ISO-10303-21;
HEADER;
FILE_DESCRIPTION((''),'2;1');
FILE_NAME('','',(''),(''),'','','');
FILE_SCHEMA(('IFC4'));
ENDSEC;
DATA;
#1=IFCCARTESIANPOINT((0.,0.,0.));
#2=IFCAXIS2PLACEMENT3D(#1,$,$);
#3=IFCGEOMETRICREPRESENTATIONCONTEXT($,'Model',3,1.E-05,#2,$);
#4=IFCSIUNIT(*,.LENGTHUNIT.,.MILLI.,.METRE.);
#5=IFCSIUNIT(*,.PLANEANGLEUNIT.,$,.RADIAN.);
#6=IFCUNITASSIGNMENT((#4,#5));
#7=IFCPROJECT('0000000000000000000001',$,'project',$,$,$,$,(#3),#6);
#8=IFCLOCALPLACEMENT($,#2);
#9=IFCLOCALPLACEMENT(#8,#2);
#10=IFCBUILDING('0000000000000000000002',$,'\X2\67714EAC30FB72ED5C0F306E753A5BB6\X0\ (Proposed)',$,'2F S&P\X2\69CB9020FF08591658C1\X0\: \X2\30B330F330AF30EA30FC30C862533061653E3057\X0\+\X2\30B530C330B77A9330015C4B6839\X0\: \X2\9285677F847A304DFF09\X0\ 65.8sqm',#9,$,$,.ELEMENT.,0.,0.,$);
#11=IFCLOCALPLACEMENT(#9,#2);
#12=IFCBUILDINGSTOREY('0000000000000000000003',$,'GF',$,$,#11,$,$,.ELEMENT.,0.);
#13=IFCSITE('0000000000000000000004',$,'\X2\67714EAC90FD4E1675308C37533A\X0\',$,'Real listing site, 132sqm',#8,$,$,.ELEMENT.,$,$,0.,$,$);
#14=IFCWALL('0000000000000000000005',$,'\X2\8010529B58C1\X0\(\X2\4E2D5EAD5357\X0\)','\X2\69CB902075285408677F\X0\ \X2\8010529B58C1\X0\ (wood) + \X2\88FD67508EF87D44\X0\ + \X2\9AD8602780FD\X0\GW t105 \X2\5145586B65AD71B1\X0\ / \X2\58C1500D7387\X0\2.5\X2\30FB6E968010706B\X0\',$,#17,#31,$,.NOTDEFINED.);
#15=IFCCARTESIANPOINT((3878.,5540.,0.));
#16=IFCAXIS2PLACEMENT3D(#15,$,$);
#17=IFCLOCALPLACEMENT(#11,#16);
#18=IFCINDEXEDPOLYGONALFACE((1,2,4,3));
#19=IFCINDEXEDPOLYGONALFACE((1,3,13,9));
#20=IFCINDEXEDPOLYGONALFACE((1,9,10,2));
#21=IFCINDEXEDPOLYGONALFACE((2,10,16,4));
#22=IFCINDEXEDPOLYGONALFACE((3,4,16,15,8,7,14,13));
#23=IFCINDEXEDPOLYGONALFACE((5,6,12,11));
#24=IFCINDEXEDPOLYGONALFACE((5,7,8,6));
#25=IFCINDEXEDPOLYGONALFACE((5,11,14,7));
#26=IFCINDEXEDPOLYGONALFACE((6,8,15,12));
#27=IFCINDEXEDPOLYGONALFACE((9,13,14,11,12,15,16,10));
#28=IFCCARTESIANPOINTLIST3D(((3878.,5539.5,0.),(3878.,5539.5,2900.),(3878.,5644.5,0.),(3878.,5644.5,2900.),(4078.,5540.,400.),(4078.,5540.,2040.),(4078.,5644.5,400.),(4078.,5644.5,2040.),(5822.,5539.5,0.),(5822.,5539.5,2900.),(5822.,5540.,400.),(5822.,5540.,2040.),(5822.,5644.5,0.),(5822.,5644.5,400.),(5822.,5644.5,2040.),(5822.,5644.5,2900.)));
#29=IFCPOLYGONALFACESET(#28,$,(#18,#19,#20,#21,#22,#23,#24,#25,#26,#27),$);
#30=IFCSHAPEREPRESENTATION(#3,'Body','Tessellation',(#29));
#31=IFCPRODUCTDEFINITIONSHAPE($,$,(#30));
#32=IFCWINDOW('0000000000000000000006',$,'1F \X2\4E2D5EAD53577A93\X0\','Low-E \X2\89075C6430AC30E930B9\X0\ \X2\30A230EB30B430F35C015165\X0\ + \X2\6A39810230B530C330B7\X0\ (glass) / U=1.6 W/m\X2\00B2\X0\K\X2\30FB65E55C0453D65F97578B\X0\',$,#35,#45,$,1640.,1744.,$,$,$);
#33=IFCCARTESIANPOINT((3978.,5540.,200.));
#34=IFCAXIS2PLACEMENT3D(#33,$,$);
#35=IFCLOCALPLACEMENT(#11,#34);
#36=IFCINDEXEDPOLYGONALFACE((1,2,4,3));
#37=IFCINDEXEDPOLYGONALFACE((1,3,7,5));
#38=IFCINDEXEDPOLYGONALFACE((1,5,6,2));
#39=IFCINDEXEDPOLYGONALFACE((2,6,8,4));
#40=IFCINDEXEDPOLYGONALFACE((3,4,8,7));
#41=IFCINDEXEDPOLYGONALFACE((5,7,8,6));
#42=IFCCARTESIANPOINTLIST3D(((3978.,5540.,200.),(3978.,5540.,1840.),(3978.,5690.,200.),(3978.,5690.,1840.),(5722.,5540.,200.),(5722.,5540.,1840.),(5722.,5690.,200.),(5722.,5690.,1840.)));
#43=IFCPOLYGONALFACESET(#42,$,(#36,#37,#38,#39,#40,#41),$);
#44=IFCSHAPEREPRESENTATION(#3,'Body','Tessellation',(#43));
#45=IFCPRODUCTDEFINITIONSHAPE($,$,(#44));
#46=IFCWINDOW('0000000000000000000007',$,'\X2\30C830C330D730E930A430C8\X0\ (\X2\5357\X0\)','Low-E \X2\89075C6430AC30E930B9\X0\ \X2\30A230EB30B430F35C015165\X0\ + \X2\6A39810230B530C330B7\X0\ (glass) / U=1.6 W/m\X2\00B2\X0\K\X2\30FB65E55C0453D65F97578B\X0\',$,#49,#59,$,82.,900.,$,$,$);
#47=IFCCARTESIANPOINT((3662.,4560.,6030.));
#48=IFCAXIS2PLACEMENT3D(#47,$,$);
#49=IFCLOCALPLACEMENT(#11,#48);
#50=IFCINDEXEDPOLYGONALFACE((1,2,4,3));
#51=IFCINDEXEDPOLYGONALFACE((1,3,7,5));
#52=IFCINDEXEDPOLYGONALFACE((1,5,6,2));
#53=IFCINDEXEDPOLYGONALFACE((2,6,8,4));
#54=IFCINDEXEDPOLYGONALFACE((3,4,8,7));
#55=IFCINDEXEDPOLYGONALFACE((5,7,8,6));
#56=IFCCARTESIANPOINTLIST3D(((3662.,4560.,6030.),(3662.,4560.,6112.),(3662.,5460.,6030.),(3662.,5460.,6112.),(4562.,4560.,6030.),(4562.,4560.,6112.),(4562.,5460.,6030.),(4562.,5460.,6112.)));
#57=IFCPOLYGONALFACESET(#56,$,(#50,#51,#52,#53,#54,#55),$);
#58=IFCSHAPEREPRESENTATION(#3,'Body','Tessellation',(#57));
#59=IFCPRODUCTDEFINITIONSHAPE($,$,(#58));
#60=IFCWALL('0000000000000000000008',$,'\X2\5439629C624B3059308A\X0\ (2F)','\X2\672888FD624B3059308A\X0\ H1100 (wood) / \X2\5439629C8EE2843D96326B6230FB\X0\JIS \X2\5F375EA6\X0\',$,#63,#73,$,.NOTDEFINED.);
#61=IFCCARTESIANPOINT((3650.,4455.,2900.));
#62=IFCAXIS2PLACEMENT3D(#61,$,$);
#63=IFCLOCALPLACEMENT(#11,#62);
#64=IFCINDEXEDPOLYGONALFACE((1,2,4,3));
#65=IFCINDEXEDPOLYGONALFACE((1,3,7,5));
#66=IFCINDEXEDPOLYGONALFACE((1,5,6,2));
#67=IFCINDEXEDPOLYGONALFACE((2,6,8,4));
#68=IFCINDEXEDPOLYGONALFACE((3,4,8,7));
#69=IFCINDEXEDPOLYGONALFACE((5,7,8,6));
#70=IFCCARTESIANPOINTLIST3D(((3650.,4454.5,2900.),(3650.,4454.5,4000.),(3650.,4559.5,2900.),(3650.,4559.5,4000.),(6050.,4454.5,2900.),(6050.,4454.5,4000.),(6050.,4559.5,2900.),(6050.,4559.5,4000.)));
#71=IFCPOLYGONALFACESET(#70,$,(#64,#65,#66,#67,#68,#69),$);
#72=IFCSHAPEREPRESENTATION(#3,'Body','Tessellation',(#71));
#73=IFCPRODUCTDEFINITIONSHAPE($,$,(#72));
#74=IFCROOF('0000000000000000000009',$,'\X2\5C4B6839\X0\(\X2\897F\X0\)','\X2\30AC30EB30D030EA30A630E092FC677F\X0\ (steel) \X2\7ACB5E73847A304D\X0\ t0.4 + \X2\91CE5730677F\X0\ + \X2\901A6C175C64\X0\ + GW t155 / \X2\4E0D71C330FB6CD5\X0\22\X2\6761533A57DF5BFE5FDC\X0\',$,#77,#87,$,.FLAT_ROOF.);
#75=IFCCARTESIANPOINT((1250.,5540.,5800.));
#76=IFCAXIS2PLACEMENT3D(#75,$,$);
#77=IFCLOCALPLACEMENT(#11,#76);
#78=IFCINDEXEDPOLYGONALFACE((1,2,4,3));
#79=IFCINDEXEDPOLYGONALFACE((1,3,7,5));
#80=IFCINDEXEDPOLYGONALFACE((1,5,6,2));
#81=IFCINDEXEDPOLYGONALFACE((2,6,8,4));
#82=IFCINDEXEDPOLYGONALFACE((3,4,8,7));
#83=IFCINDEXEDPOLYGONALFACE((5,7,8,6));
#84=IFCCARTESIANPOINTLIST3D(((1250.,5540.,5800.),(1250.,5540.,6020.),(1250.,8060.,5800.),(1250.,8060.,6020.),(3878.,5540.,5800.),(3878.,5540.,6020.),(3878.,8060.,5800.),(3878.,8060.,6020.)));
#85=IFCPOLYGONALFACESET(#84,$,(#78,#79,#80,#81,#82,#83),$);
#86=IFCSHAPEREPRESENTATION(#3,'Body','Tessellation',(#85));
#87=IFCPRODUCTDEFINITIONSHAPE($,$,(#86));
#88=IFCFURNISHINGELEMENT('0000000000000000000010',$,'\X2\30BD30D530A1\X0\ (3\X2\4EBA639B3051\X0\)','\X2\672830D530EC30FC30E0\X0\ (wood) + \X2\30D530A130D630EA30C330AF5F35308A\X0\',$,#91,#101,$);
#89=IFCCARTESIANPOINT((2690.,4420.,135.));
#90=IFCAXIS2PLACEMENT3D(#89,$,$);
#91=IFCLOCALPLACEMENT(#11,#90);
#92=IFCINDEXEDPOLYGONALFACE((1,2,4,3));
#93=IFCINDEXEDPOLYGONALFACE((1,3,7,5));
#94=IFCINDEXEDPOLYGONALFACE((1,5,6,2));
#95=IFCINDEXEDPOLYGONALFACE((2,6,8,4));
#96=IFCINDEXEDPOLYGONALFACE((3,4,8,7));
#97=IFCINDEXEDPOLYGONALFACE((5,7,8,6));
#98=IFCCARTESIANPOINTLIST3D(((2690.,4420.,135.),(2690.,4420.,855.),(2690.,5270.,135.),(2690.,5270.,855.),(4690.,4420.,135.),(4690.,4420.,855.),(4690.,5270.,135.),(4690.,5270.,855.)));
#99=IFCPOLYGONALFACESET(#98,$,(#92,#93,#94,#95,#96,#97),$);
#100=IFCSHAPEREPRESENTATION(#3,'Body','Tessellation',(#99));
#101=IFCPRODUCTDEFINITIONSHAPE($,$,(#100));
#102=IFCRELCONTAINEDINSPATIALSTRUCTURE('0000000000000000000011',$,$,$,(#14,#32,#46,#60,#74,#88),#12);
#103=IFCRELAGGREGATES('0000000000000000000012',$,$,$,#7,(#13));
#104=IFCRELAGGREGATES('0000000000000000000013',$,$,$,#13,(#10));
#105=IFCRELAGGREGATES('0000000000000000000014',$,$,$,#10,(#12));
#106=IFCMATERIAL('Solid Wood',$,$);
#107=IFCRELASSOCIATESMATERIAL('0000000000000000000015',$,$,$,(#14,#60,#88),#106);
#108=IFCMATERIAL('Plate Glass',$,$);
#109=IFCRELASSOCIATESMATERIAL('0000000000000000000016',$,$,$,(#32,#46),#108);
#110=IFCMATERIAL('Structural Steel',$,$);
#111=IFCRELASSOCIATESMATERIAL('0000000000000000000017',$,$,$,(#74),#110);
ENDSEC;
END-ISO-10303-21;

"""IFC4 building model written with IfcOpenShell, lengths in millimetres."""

from ifc_helpers import new_model, si_unit, frame, frame_2d, origin, place, context, project, spatial, rectangle, extrude, material, element, fill, save


model = new_model("IFC4")

# Units and contexts
model_context = context("Model", 3, precision=1e-05, world=origin())
ifc_project = project(units=[si_unit("LENGTHUNIT", "METRE", prefix="MILLI"), si_unit("PLANEANGLEUNIT", "RADIAN")], contexts=[model_context])

# Site, building, storey
site_placement = place(None, origin())
site = spatial("IfcSite", under=ifc_project, at=site_placement, Name="東京都世田谷区", ObjectType="Real listing site, 132sqm", CompositionType="ELEMENT", RefElevation=0.0)
building_placement = place(site_placement, origin())
building = spatial("IfcBuilding", under=site, at=building_placement, Name="東京・狭小の町家 (Proposed)", ObjectType="2F S&P構造（外壁: コンクリート打ち放し+サッシ窓、屋根: 銅板葺き） 65.8sqm", CompositionType="ELEMENT", ElevationOfRefHeight=0.0, ElevationOfTerrain=0.0)
storey_placement = place(building_placement, origin())
storey = spatial("IfcBuildingStorey", under=building, at=storey_placement, Name="GF", CompositionType="ELEMENT", Elevation=0.0)

# Shared definitions
ifc_material_1 = material(Name="Solid Wood")

# Wall, opening, window
wall_1_placement = place(storey_placement, frame((3878.0, 5540.0, 0.0)))
wall_1 = element("IfcWall", 1, at=wall_1_placement, inside=storey, material=ifc_material_1, Name="耐力壁(中庭南)", Description="構造用合板 耐力壁 (wood) + 製材軸組 + 高性能GW t105 充填断熱 / 壁倍率2.5・準耐火", PredefinedType="NOTDEFINED", context=model_context, shape_type="SweptSolid", body=[
    extrude(rectangle(XDim=1944.0, YDim=105.0, at=frame_2d((972.0, 52.0))), frame((3878.0, 5540.0, 0.0)), (0.0, 0.0, 1.0), 2900.0),
])
opening_placement = place(storey_placement, frame((3978.0, 5540.0, 200.0)))
opening = element("IfcOpeningElement", 2, at=opening_placement, cuts=wall_1, PredefinedType="NOTDEFINED", context=model_context, shape_type="SweptSolid", body=[
    extrude(rectangle(XDim=1744.0, YDim=150.0, at=frame_2d((872.0, 75.0))), frame((3978.0, 5540.0, 200.0)), (0.0, 0.0, 1.0), 1640.0),
])
ifc_material_2 = material(Name="Plate Glass")
window_1_placement = place(storey_placement, frame((3978.0, 5540.0, 200.0)))
window_1 = element("IfcWindow", 3, at=window_1_placement, inside=storey, material=ifc_material_2, Name="1F 中庭南窓", Description="Low-E 複層ガラス アルゴン封入 + 樹脂サッシ (glass) / U=1.6 W/m²K・日射取得型", OverallHeight=1640.0, OverallWidth=1744.0, context=model_context, shape_type="SweptSolid", body=[
    extrude(rectangle(XDim=1744.0, YDim=150.0, at=frame_2d((872.0, 75.0))), frame((3978.0, 5540.0, 200.0)), (0.0, 0.0, 1.0), 1640.0),
])
fill(opening, window_1)

# Window
window_2_placement = place(storey_placement, frame((3662.0, 4560.0, 6030.0)))
element("IfcWindow", 4, at=window_2_placement, inside=storey, material=ifc_material_2, Name="トップライト (南)", Description="Low-E 複層ガラス アルゴン封入 + 樹脂サッシ (glass) / U=1.6 W/m²K・日射取得型", OverallHeight=82.0, OverallWidth=900.0, context=model_context, shape_type="SweptSolid", body=[
    extrude(rectangle(XDim=900.0, YDim=900.0, at=frame_2d((450.0, 450.0))), frame((3662.0, 4560.0, 6030.0)), (0.0, 0.0, 1.0), 82.0),
])

# Wall
wall_2_placement = place(storey_placement, frame((3650.0, 4455.0, 2900.0)))
element("IfcWall", 5, at=wall_2_placement, inside=storey, material=ifc_material_1, Name="吹抜手すり (2F)", Description="木製手すり H1100 (wood) / 吹抜転落防止・JIS 強度", PredefinedType="NOTDEFINED", context=model_context, shape_type="SweptSolid", body=[
    extrude(rectangle(XDim=2400.0, YDim=105.0, at=frame_2d((1200.0, 52.0))), frame((3650.0, 4455.0, 2900.0)), (0.0, 0.0, 1.0), 1100.0),
])

# Roof
ifc_material_3 = material(Name="Structural Steel")
for number, where, name in (
    (6, (1250.0, 5540.0, 5800.0), "屋根(西)"),
):
    element("IfcRoof", number, at=place(storey_placement, frame(where)), inside=storey, material=ifc_material_3, Name=name, Description="ガルバリウム鋼板 (steel) 立平葺き t0.4 + 野地板 + 通気層 + GW t155 / 不燃・法22条区域対応", PredefinedType="FLAT_ROOF", context=model_context, shape_type="SweptSolid", body=[
        extrude(rectangle(XDim=2628.0, YDim=2520.0, at=frame_2d((1314.0, 1260.0))), frame((1250.0, 5540.0, 5800.0)), (0.0, 0.0, 1.0), 220.0),
    ])

# Furnishing element
furnishing_placement = place(storey_placement, frame((2690.0, 4420.0, 135.0)))
element("IfcFurnishingElement", 7, at=furnishing_placement, inside=storey, material=ifc_material_1, Name="ソファ (3人掛け)", Description="木フレーム (wood) + ファブリック張り", context=model_context, shape_type="SweptSolid", body=[
    extrude(rectangle(XDim=2000.0, YDim=850.0, at=frame_2d((1000.0, 425.0))), frame((2690.0, 4420.0, 135.0)), (0.0, 0.0, 1.0), 720.0),
])

save(model, "model.ifc")
